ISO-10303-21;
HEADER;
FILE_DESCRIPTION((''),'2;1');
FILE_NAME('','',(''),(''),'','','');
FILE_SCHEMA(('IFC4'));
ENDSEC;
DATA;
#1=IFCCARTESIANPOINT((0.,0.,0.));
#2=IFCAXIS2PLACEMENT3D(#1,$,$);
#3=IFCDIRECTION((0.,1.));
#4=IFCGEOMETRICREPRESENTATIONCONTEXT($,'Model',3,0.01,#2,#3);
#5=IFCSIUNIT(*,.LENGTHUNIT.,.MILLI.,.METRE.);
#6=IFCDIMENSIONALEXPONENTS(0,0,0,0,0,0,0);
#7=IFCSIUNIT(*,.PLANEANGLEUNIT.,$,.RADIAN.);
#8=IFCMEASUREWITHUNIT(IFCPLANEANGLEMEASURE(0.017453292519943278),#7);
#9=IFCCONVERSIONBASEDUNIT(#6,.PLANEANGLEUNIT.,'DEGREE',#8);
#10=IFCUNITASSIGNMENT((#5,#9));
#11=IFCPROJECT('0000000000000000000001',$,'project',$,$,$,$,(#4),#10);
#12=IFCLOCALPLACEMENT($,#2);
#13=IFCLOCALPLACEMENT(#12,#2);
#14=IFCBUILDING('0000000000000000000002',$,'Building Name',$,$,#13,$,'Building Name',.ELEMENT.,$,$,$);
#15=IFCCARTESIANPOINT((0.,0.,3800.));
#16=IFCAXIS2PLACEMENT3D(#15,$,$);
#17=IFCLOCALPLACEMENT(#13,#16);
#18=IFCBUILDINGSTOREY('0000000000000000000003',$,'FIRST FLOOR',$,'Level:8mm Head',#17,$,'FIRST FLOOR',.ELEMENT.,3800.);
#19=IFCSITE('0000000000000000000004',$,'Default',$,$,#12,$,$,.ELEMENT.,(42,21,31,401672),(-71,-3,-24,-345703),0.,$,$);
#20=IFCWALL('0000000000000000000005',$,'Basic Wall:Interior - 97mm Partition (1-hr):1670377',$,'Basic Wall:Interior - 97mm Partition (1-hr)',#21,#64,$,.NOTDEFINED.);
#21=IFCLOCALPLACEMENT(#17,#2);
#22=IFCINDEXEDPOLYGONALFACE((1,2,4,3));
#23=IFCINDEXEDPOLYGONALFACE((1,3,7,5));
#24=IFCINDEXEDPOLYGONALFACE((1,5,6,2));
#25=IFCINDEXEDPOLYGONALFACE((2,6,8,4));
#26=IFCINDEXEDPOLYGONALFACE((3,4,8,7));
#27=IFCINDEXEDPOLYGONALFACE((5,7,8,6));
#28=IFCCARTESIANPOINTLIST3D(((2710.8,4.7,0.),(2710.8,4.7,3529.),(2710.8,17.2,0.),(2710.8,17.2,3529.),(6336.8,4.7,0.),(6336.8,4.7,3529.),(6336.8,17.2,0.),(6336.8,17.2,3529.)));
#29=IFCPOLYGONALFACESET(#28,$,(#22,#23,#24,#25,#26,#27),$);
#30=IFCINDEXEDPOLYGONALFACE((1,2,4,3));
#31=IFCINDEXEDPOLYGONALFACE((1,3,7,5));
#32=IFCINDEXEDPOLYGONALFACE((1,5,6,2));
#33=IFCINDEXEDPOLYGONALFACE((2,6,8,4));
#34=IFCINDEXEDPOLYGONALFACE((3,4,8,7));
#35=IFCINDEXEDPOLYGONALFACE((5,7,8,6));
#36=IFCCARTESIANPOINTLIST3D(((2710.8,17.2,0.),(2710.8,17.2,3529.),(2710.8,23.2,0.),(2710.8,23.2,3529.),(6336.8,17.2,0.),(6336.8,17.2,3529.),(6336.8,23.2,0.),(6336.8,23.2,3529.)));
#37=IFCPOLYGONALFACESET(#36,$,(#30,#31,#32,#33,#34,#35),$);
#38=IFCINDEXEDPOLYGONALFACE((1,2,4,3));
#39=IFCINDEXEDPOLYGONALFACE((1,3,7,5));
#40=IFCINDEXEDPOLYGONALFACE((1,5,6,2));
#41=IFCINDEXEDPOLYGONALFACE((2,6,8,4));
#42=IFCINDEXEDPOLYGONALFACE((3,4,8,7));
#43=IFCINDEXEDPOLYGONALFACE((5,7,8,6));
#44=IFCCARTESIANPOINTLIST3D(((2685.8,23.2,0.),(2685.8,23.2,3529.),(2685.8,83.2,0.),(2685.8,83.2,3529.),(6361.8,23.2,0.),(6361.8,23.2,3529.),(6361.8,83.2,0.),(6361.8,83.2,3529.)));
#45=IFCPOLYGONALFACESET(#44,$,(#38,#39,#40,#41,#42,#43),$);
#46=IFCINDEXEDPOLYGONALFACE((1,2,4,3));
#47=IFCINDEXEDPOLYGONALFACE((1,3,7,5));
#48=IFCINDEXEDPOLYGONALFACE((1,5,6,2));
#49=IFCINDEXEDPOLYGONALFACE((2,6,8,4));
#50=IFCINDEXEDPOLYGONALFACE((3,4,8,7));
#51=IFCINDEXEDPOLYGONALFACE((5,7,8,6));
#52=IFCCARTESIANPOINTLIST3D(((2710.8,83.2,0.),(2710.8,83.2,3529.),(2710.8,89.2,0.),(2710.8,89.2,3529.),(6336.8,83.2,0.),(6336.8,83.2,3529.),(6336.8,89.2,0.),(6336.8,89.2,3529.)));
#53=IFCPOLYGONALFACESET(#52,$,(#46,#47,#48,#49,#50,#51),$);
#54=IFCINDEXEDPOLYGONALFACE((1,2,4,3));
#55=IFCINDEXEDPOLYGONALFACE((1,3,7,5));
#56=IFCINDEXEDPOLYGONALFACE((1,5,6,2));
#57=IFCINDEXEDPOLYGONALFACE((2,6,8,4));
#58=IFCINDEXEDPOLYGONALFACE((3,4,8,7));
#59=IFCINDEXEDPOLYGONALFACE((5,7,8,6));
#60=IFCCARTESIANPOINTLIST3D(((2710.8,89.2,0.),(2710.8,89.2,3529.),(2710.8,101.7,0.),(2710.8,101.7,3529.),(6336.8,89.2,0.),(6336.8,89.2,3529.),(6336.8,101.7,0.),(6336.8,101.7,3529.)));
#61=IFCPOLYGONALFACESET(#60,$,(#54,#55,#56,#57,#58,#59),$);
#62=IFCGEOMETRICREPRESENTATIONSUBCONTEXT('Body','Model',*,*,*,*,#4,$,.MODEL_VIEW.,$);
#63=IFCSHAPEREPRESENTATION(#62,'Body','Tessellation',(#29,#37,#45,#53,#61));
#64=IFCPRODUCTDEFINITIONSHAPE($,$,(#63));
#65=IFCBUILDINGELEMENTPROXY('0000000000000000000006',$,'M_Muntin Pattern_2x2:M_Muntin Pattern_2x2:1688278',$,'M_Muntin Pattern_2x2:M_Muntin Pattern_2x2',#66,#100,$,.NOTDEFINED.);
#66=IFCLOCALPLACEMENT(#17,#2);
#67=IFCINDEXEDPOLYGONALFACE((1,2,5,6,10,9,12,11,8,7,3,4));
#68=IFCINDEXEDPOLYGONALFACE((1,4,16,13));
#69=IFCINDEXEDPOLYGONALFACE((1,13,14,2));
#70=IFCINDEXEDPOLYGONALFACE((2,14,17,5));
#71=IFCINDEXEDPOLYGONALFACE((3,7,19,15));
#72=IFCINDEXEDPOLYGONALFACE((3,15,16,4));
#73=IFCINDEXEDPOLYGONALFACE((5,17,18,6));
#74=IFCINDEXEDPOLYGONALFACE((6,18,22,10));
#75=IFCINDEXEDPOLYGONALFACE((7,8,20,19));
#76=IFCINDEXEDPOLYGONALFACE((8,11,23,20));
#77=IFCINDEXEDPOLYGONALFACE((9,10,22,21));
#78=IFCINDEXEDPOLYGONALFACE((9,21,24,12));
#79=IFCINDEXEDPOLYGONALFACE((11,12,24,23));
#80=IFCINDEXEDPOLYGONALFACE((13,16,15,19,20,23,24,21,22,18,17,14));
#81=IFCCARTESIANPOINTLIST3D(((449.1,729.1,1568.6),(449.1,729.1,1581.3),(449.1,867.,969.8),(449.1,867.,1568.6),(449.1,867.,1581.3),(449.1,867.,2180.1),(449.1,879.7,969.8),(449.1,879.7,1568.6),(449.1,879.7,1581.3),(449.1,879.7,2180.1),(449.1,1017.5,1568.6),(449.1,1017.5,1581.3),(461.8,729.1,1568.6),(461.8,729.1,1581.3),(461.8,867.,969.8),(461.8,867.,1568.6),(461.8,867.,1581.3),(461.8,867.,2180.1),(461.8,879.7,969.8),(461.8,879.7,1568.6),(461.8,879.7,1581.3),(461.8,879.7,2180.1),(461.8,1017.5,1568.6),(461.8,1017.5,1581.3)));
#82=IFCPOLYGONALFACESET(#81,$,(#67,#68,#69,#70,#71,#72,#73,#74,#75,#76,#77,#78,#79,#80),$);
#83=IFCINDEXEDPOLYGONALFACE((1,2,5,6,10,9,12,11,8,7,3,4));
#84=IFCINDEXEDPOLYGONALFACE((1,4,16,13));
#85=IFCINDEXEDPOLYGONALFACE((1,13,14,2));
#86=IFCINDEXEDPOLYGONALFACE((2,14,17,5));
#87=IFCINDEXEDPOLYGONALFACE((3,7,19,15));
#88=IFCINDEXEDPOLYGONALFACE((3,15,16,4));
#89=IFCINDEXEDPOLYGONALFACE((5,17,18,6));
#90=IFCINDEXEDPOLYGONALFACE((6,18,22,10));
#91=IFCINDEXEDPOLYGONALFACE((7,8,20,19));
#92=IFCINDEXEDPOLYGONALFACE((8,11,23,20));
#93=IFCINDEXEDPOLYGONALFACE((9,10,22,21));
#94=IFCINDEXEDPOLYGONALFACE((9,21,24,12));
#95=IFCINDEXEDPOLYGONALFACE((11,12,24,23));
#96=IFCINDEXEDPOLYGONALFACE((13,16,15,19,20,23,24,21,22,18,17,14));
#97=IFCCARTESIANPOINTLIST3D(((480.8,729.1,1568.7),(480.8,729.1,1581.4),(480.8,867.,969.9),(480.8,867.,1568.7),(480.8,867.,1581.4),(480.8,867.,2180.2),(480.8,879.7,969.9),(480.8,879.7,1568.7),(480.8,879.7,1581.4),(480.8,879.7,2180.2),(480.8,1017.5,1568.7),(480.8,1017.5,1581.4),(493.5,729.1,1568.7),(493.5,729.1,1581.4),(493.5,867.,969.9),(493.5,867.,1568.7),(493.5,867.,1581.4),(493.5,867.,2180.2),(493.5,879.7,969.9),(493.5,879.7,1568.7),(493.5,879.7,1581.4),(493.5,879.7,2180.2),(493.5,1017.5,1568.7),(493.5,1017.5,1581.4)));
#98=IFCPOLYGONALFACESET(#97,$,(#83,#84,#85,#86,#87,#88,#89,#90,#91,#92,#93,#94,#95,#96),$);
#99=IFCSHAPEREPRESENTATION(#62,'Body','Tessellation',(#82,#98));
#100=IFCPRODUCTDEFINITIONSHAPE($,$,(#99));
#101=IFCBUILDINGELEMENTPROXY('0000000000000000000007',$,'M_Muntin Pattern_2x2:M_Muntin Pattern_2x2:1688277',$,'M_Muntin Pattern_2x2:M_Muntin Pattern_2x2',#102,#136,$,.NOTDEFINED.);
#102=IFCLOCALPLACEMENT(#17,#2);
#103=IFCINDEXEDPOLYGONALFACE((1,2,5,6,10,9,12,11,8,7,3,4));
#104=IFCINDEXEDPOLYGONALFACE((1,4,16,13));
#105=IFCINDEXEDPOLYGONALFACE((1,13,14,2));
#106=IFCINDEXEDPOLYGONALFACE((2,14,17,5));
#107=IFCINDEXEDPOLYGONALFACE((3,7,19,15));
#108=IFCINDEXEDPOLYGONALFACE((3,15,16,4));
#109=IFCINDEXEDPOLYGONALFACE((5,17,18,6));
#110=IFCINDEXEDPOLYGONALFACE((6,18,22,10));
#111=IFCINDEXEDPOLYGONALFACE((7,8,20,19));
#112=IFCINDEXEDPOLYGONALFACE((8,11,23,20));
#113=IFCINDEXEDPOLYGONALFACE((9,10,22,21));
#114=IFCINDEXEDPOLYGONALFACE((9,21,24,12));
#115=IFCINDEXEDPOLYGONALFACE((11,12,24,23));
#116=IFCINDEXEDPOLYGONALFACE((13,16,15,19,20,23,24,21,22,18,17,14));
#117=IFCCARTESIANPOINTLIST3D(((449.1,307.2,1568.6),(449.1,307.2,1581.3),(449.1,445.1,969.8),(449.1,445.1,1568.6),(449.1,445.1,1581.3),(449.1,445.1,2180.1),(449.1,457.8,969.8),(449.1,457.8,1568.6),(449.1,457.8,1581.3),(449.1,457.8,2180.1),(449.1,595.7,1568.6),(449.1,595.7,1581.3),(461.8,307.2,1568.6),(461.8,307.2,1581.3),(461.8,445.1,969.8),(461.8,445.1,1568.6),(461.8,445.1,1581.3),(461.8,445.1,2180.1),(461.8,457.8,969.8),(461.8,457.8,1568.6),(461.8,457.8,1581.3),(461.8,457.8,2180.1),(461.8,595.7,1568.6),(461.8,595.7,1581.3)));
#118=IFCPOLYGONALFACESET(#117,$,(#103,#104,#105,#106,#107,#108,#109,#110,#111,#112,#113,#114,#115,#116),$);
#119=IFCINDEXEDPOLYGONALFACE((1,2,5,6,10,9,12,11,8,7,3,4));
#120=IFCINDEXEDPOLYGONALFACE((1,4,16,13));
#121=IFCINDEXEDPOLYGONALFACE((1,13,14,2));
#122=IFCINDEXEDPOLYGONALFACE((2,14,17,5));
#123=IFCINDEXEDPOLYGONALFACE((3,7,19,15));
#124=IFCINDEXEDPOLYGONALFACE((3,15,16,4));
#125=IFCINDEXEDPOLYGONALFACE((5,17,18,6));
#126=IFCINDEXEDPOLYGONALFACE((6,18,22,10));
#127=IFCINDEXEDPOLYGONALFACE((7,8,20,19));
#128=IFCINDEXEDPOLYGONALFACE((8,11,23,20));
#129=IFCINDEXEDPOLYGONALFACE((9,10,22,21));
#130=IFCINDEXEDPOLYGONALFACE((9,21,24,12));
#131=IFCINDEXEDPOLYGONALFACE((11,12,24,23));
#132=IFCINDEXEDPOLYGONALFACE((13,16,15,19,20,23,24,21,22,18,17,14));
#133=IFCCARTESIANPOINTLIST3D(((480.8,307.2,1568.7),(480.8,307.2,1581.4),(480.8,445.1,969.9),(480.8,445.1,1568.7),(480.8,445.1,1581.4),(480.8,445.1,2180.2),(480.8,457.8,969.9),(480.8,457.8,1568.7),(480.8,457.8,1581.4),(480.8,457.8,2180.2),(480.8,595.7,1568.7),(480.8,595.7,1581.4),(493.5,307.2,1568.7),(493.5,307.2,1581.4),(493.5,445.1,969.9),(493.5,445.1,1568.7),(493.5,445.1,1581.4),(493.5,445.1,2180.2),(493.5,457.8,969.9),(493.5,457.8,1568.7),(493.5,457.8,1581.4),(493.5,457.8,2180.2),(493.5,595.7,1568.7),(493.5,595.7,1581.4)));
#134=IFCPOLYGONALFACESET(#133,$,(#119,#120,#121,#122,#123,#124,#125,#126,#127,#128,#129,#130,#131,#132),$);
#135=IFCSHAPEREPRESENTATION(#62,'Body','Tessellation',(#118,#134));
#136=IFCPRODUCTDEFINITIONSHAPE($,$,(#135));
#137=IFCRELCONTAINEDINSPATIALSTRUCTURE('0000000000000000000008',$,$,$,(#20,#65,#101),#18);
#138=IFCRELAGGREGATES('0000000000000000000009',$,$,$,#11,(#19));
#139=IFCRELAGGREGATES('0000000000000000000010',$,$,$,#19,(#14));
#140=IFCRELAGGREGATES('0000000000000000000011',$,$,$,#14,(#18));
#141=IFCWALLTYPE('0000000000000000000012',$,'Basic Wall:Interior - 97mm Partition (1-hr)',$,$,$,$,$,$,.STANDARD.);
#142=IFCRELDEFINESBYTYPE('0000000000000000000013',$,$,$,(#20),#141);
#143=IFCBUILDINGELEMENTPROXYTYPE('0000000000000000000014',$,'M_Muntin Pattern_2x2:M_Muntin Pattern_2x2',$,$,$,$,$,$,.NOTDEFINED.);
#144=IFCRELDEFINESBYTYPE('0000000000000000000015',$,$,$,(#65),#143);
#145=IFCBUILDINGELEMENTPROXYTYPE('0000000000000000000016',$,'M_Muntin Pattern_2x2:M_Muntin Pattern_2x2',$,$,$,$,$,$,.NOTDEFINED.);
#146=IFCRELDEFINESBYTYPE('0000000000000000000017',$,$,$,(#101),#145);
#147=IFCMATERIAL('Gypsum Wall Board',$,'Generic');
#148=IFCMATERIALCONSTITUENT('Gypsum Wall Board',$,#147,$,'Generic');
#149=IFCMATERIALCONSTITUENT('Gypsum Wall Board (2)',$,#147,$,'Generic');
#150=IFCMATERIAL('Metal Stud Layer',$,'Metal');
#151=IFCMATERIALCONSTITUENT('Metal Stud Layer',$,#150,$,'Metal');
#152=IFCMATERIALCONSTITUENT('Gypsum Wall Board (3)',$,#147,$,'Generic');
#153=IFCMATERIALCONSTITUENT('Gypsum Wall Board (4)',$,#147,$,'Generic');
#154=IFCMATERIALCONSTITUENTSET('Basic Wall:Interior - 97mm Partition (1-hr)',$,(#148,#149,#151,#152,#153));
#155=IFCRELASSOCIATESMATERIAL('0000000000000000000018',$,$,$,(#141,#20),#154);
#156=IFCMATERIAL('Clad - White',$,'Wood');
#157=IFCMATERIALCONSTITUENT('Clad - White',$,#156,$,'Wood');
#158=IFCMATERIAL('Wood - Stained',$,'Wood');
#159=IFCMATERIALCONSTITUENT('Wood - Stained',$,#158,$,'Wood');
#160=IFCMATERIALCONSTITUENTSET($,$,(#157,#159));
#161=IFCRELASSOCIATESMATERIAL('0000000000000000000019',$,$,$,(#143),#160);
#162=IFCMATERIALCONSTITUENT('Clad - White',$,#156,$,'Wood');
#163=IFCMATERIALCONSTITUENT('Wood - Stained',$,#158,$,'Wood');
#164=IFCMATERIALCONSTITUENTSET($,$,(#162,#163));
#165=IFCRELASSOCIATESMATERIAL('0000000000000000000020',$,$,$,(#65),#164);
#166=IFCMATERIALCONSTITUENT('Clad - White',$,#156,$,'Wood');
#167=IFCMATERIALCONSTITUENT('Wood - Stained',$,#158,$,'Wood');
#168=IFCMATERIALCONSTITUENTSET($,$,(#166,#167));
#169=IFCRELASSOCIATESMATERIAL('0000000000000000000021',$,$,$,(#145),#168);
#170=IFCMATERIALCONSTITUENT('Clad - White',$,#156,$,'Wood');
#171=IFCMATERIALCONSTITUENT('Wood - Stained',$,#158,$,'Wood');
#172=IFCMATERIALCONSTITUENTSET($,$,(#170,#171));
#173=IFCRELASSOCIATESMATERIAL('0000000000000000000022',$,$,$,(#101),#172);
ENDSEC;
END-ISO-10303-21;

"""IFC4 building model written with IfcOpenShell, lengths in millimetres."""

from ifc_helpers import new_model, entity, si_unit, converted_unit, direction, frame, origin, place, context, subcontext, project, spatial, indexed_curve, outline, extrude, source, transform, mapped, material, constituent, constituent_set, type_object, type_shapes, element, save


model = new_model("IFC4")

# Units and contexts
model_context = context("Model", 3, precision=0.01, world=origin(), true_north=direction((0.0, 1.0)))
body_context = subcontext(model_context, "Body", "Model", "MODEL_VIEW")
ifc_project = project(units=[si_unit("LENGTHUNIT", "METRE", prefix="MILLI"), converted_unit("PLANEANGLEUNIT", "DEGREE", entity("IfcPlaneAngleMeasure", 0.017453292519943278), si_unit("PLANEANGLEUNIT", "RADIAN"), dimensions=[0, 0, 0, 0, 0, 0, 0])], contexts=[model_context])

# Site, building, storey
site_placement = place(None, origin())
site = spatial("IfcSite", under=ifc_project, at=site_placement, Name="Default", CompositionType="ELEMENT", RefLatitude=(42, 21, 31, 401672), RefLongitude=(-71, -3, -24, -345703), RefElevation=0.0)
building_placement = place(site_placement, origin())
building = spatial("IfcBuilding", under=site, at=building_placement, Name="Building Name", LongName="Building Name", CompositionType="ELEMENT")
storey_placement = place(building_placement, frame((0.0, 0.0, 3800.0)))
storey = spatial("IfcBuildingStorey", under=building, at=storey_placement, Name="FIRST FLOOR", ObjectType="Level:8mm Head", LongName="FIRST FLOOR", CompositionType="ELEMENT", Elevation=3800.0)

# Wall
ifc_material_1 = material(Name="Gypsum Wall Board", Category="Generic")
ifc_constituent_1 = constituent(ifc_material_1, Name="Gypsum Wall Board", Category="Generic")
ifc_constituent_2 = constituent(ifc_material_1, Name="Gypsum Wall Board (2)", Category="Generic")
ifc_material_2 = material(Name="Metal Stud Layer", Category="Metal")
ifc_constituent_3 = constituent(ifc_material_2, Name="Metal Stud Layer", Category="Metal")
ifc_constituent_4 = constituent(ifc_material_1, Name="Gypsum Wall Board (3)", Category="Generic")
ifc_constituent_5 = constituent(ifc_material_1, Name="Gypsum Wall Board (4)", Category="Generic")
ifc_constituent_set_1 = constituent_set(constituents=[ifc_constituent_1, ifc_constituent_2, ifc_constituent_3, ifc_constituent_4, ifc_constituent_5], Name="Basic Wall:Interior - 97mm Partition (1-hr)")
wall_type = type_object("IfcWallType", Name="Basic Wall:Interior - 97mm Partition (1-hr)", PredefinedType="STANDARD", material=ifc_constituent_set_1)
wall_1_placement = place(storey_placement, frame((6336.8, 53.2, 0.0), z_axis=(0.0, 0.0, 1.0), x_axis=(-1.0, 0.0, 0.0)))
element("IfcWall", 1, at=wall_1_placement, inside=storey, type_object=wall_type, material=ifc_constituent_set_1, Name="Basic Wall:Interior - 97mm Partition (1-hr):1670377", ObjectType="Basic Wall:Interior - 97mm Partition (1-hr)", PredefinedType="NOTDEFINED", context=body_context, shape_type="SweptSolid", body=[
    extrude(outline(indexed_curve([(-6.3, -1764.5), (6.2, -1764.5), (6.3, 1764.5), (-6.3, 1764.5), (-6.3, -1764.5)], self_intersect=False)), frame((3626.0, 42.2, 1764.5), z_axis=(-1.0, 0.0, 0.0), x_axis=(0.0, -1.0, 0.0)), (0.0, 0.0, 1.0), 3626.0),
    extrude(outline(indexed_curve([(-1764.5, -3.0), (1764.5, -3.0), (1764.5, 3.0), (-1764.5, 3.0), (-1764.5, -3.0)], self_intersect=False)), frame((3626.0, 33.0, 1764.5), z_axis=(-1.0, 0.0, 0.0), x_axis=(0.0, 0.0, 1.0)), (0.0, 0.0, 1.0), 3626.0),
    extrude(outline(indexed_curve([(-1764.5, -30.0), (1764.5, -30.0), (1764.5, 30.0), (-1764.5, 30.0), (-1764.5, -30.0)], self_intersect=False)), frame((3651.0, 0.0, 1764.5), z_axis=(-1.0, 0.0, 0.0), x_axis=(0.0, 0.0, 1.0)), (0.0, 0.0, 1.0), 3676.0),
    extrude(outline(indexed_curve([(-1764.5, -3.0), (1764.5, -3.0), (1764.5, 3.0), (-1764.5, 3.0), (-1764.5, -3.0)], self_intersect=False)), frame((3626.0, -33.0, 1764.5), z_axis=(-1.0, 0.0, 0.0), x_axis=(0.0, 0.0, 1.0)), (0.0, 0.0, 1.0), 3626.0),
    extrude(outline(indexed_curve([(-6.3, -1764.5), (6.2, -1764.5), (6.2, 1764.5), (-6.3, 1764.5), (-6.3, -1764.5)], self_intersect=False)), frame((3626.0, -42.2, 1764.5), z_axis=(-1.0, 0.0, 0.0), x_axis=(0.0, 1.0, 0.0)), (0.0, 0.0, 1.0), 3626.0),
])

# Building element proxies
ifc_material_3 = material(Name="Clad - White", Category="Wood")
ifc_constituent_6 = constituent(ifc_material_3, Name="Clad - White", Category="Wood")
ifc_material_4 = material(Name="Wood - Stained", Category="Wood")
ifc_constituent_7 = constituent(ifc_material_4, Name="Wood - Stained", Category="Wood")
ifc_constituent_set_2 = constituent_set(constituents=[ifc_constituent_6, ifc_constituent_7])
ifc_constituent_8 = constituent(ifc_material_3, Name="Clad - White", Category="Wood")
ifc_constituent_9 = constituent(ifc_material_4, Name="Wood - Stained", Category="Wood")
ifc_constituent_set_3 = constituent_set(constituents=[ifc_constituent_8, ifc_constituent_9])
building_element_proxy_type_1 = type_object("IfcBuildingElementProxyType", Name="M_Muntin Pattern_2x2:M_Muntin Pattern_2x2", PredefinedType="NOTDEFINED", material=ifc_constituent_set_3)
shared_shape_1 = source(origin(), body_context, "Body", "SweptSolid", [
    extrude(outline(indexed_curve([(6.4, -6.4), (605.1, -6.4), (605.1, 6.3), (6.4, 6.3), (6.4, 144.2), (-6.3, 144.2), (-6.3, 6.3), (-605.2, 6.3), (-605.2, -6.4), (-6.3, -6.4), (-6.3, -144.2), (6.4, -144.2), (6.4, -6.4)], self_intersect=False)), frame((0.0, -22.2, 605.1), z_axis=(0.0, 1.0, 0.0), x_axis=(0.0, 0.0, 1.0)), (0.0, 0.0, 1.0), 12.7),
    extrude(outline(indexed_curve([(6.4, -6.4), (605.2, -6.4), (605.2, 6.3), (6.4, 6.3), (6.4, 144.2), (-6.3, 144.2), (-6.3, 6.3), (-605.2, 6.3), (-605.2, -6.4), (-6.3, -6.4), (-6.3, -144.2), (6.4, -144.2), (6.4, -6.4)], self_intersect=False)), frame((0.0, 9.5, 605.2), z_axis=(0.0, 1.0, 0.0), x_axis=(0.0, 0.0, 1.0)), (0.0, 0.0, 1.0), 12.7),
])
type_shapes(building_element_proxy_type_1, [shared_shape_1])
proxy_1_placement = place(storey_placement, frame((471.3, 873.3, 969.9), z_axis=(0.0, 0.0, 1.0), x_axis=(0.0, -1.0, 0.0)))
element("IfcBuildingElementProxy", 2, at=proxy_1_placement, inside=storey, type_object=building_element_proxy_type_1, material=ifc_constituent_set_2, Name="M_Muntin Pattern_2x2:M_Muntin Pattern_2x2:1688278", ObjectType="M_Muntin Pattern_2x2:M_Muntin Pattern_2x2", PredefinedType="NOTDEFINED", context=body_context, shape_type="MappedRepresentation", body=[
    mapped(shared_shape_1, transform((0.0, 0.0, 0.0), scale=1.0)),
])
ifc_constituent_10 = constituent(ifc_material_3, Name="Clad - White", Category="Wood")
ifc_constituent_11 = constituent(ifc_material_4, Name="Wood - Stained", Category="Wood")
ifc_constituent_set_4 = constituent_set(constituents=[ifc_constituent_10, ifc_constituent_11])
ifc_constituent_12 = constituent(ifc_material_3, Name="Clad - White", Category="Wood")
ifc_constituent_13 = constituent(ifc_material_4, Name="Wood - Stained", Category="Wood")
ifc_constituent_set_5 = constituent_set(constituents=[ifc_constituent_12, ifc_constituent_13])
building_element_proxy_type_2 = type_object("IfcBuildingElementProxyType", Name="M_Muntin Pattern_2x2:M_Muntin Pattern_2x2", PredefinedType="NOTDEFINED", material=ifc_constituent_set_5)
shared_shape_2 = source(origin(), body_context, "Body", "SweptSolid", [
    extrude(outline(indexed_curve([(6.4, -6.4), (605.1, -6.4), (605.1, 6.3), (6.4, 6.3), (6.4, 144.2), (-6.3, 144.2), (-6.3, 6.3), (-605.2, 6.3), (-605.2, -6.4), (-6.3, -6.4), (-6.3, -144.2), (6.4, -144.2), (6.4, -6.4)], self_intersect=False)), frame((0.0, 9.5, 605.1), z_axis=(0.0, 1.0, 0.0), x_axis=(0.0, 0.0, 1.0)), (0.0, 0.0, 1.0), 12.7),
    extrude(outline(indexed_curve([(6.4, -6.4), (605.2, -6.4), (605.2, 6.3), (6.4, 6.3), (6.4, 144.2), (-6.3, 144.2), (-6.3, 6.3), (-605.2, 6.3), (-605.2, -6.4), (-6.3, -6.4), (-6.3, -144.2), (6.4, -144.2), (6.4, -6.4)], self_intersect=False)), frame((0.0, -22.2, 605.2), z_axis=(0.0, 1.0, 0.0), x_axis=(0.0, 0.0, 1.0)), (0.0, 0.0, 1.0), 12.7),
])
type_shapes(building_element_proxy_type_2, [shared_shape_2])
proxy_2_placement = place(storey_placement, frame((471.3, 451.5, 969.9), z_axis=(0.0, 0.0, 1.0), x_axis=(0.0, 1.0, 0.0)))
element("IfcBuildingElementProxy", 3, at=proxy_2_placement, inside=storey, type_object=building_element_proxy_type_2, material=ifc_constituent_set_4, Name="M_Muntin Pattern_2x2:M_Muntin Pattern_2x2:1688277", ObjectType="M_Muntin Pattern_2x2:M_Muntin Pattern_2x2", PredefinedType="NOTDEFINED", context=body_context, shape_type="MappedRepresentation", body=[
    mapped(shared_shape_2, transform((0.0, 0.0, 0.0), scale=1.0)),
])

save(model, "model.ifc")
